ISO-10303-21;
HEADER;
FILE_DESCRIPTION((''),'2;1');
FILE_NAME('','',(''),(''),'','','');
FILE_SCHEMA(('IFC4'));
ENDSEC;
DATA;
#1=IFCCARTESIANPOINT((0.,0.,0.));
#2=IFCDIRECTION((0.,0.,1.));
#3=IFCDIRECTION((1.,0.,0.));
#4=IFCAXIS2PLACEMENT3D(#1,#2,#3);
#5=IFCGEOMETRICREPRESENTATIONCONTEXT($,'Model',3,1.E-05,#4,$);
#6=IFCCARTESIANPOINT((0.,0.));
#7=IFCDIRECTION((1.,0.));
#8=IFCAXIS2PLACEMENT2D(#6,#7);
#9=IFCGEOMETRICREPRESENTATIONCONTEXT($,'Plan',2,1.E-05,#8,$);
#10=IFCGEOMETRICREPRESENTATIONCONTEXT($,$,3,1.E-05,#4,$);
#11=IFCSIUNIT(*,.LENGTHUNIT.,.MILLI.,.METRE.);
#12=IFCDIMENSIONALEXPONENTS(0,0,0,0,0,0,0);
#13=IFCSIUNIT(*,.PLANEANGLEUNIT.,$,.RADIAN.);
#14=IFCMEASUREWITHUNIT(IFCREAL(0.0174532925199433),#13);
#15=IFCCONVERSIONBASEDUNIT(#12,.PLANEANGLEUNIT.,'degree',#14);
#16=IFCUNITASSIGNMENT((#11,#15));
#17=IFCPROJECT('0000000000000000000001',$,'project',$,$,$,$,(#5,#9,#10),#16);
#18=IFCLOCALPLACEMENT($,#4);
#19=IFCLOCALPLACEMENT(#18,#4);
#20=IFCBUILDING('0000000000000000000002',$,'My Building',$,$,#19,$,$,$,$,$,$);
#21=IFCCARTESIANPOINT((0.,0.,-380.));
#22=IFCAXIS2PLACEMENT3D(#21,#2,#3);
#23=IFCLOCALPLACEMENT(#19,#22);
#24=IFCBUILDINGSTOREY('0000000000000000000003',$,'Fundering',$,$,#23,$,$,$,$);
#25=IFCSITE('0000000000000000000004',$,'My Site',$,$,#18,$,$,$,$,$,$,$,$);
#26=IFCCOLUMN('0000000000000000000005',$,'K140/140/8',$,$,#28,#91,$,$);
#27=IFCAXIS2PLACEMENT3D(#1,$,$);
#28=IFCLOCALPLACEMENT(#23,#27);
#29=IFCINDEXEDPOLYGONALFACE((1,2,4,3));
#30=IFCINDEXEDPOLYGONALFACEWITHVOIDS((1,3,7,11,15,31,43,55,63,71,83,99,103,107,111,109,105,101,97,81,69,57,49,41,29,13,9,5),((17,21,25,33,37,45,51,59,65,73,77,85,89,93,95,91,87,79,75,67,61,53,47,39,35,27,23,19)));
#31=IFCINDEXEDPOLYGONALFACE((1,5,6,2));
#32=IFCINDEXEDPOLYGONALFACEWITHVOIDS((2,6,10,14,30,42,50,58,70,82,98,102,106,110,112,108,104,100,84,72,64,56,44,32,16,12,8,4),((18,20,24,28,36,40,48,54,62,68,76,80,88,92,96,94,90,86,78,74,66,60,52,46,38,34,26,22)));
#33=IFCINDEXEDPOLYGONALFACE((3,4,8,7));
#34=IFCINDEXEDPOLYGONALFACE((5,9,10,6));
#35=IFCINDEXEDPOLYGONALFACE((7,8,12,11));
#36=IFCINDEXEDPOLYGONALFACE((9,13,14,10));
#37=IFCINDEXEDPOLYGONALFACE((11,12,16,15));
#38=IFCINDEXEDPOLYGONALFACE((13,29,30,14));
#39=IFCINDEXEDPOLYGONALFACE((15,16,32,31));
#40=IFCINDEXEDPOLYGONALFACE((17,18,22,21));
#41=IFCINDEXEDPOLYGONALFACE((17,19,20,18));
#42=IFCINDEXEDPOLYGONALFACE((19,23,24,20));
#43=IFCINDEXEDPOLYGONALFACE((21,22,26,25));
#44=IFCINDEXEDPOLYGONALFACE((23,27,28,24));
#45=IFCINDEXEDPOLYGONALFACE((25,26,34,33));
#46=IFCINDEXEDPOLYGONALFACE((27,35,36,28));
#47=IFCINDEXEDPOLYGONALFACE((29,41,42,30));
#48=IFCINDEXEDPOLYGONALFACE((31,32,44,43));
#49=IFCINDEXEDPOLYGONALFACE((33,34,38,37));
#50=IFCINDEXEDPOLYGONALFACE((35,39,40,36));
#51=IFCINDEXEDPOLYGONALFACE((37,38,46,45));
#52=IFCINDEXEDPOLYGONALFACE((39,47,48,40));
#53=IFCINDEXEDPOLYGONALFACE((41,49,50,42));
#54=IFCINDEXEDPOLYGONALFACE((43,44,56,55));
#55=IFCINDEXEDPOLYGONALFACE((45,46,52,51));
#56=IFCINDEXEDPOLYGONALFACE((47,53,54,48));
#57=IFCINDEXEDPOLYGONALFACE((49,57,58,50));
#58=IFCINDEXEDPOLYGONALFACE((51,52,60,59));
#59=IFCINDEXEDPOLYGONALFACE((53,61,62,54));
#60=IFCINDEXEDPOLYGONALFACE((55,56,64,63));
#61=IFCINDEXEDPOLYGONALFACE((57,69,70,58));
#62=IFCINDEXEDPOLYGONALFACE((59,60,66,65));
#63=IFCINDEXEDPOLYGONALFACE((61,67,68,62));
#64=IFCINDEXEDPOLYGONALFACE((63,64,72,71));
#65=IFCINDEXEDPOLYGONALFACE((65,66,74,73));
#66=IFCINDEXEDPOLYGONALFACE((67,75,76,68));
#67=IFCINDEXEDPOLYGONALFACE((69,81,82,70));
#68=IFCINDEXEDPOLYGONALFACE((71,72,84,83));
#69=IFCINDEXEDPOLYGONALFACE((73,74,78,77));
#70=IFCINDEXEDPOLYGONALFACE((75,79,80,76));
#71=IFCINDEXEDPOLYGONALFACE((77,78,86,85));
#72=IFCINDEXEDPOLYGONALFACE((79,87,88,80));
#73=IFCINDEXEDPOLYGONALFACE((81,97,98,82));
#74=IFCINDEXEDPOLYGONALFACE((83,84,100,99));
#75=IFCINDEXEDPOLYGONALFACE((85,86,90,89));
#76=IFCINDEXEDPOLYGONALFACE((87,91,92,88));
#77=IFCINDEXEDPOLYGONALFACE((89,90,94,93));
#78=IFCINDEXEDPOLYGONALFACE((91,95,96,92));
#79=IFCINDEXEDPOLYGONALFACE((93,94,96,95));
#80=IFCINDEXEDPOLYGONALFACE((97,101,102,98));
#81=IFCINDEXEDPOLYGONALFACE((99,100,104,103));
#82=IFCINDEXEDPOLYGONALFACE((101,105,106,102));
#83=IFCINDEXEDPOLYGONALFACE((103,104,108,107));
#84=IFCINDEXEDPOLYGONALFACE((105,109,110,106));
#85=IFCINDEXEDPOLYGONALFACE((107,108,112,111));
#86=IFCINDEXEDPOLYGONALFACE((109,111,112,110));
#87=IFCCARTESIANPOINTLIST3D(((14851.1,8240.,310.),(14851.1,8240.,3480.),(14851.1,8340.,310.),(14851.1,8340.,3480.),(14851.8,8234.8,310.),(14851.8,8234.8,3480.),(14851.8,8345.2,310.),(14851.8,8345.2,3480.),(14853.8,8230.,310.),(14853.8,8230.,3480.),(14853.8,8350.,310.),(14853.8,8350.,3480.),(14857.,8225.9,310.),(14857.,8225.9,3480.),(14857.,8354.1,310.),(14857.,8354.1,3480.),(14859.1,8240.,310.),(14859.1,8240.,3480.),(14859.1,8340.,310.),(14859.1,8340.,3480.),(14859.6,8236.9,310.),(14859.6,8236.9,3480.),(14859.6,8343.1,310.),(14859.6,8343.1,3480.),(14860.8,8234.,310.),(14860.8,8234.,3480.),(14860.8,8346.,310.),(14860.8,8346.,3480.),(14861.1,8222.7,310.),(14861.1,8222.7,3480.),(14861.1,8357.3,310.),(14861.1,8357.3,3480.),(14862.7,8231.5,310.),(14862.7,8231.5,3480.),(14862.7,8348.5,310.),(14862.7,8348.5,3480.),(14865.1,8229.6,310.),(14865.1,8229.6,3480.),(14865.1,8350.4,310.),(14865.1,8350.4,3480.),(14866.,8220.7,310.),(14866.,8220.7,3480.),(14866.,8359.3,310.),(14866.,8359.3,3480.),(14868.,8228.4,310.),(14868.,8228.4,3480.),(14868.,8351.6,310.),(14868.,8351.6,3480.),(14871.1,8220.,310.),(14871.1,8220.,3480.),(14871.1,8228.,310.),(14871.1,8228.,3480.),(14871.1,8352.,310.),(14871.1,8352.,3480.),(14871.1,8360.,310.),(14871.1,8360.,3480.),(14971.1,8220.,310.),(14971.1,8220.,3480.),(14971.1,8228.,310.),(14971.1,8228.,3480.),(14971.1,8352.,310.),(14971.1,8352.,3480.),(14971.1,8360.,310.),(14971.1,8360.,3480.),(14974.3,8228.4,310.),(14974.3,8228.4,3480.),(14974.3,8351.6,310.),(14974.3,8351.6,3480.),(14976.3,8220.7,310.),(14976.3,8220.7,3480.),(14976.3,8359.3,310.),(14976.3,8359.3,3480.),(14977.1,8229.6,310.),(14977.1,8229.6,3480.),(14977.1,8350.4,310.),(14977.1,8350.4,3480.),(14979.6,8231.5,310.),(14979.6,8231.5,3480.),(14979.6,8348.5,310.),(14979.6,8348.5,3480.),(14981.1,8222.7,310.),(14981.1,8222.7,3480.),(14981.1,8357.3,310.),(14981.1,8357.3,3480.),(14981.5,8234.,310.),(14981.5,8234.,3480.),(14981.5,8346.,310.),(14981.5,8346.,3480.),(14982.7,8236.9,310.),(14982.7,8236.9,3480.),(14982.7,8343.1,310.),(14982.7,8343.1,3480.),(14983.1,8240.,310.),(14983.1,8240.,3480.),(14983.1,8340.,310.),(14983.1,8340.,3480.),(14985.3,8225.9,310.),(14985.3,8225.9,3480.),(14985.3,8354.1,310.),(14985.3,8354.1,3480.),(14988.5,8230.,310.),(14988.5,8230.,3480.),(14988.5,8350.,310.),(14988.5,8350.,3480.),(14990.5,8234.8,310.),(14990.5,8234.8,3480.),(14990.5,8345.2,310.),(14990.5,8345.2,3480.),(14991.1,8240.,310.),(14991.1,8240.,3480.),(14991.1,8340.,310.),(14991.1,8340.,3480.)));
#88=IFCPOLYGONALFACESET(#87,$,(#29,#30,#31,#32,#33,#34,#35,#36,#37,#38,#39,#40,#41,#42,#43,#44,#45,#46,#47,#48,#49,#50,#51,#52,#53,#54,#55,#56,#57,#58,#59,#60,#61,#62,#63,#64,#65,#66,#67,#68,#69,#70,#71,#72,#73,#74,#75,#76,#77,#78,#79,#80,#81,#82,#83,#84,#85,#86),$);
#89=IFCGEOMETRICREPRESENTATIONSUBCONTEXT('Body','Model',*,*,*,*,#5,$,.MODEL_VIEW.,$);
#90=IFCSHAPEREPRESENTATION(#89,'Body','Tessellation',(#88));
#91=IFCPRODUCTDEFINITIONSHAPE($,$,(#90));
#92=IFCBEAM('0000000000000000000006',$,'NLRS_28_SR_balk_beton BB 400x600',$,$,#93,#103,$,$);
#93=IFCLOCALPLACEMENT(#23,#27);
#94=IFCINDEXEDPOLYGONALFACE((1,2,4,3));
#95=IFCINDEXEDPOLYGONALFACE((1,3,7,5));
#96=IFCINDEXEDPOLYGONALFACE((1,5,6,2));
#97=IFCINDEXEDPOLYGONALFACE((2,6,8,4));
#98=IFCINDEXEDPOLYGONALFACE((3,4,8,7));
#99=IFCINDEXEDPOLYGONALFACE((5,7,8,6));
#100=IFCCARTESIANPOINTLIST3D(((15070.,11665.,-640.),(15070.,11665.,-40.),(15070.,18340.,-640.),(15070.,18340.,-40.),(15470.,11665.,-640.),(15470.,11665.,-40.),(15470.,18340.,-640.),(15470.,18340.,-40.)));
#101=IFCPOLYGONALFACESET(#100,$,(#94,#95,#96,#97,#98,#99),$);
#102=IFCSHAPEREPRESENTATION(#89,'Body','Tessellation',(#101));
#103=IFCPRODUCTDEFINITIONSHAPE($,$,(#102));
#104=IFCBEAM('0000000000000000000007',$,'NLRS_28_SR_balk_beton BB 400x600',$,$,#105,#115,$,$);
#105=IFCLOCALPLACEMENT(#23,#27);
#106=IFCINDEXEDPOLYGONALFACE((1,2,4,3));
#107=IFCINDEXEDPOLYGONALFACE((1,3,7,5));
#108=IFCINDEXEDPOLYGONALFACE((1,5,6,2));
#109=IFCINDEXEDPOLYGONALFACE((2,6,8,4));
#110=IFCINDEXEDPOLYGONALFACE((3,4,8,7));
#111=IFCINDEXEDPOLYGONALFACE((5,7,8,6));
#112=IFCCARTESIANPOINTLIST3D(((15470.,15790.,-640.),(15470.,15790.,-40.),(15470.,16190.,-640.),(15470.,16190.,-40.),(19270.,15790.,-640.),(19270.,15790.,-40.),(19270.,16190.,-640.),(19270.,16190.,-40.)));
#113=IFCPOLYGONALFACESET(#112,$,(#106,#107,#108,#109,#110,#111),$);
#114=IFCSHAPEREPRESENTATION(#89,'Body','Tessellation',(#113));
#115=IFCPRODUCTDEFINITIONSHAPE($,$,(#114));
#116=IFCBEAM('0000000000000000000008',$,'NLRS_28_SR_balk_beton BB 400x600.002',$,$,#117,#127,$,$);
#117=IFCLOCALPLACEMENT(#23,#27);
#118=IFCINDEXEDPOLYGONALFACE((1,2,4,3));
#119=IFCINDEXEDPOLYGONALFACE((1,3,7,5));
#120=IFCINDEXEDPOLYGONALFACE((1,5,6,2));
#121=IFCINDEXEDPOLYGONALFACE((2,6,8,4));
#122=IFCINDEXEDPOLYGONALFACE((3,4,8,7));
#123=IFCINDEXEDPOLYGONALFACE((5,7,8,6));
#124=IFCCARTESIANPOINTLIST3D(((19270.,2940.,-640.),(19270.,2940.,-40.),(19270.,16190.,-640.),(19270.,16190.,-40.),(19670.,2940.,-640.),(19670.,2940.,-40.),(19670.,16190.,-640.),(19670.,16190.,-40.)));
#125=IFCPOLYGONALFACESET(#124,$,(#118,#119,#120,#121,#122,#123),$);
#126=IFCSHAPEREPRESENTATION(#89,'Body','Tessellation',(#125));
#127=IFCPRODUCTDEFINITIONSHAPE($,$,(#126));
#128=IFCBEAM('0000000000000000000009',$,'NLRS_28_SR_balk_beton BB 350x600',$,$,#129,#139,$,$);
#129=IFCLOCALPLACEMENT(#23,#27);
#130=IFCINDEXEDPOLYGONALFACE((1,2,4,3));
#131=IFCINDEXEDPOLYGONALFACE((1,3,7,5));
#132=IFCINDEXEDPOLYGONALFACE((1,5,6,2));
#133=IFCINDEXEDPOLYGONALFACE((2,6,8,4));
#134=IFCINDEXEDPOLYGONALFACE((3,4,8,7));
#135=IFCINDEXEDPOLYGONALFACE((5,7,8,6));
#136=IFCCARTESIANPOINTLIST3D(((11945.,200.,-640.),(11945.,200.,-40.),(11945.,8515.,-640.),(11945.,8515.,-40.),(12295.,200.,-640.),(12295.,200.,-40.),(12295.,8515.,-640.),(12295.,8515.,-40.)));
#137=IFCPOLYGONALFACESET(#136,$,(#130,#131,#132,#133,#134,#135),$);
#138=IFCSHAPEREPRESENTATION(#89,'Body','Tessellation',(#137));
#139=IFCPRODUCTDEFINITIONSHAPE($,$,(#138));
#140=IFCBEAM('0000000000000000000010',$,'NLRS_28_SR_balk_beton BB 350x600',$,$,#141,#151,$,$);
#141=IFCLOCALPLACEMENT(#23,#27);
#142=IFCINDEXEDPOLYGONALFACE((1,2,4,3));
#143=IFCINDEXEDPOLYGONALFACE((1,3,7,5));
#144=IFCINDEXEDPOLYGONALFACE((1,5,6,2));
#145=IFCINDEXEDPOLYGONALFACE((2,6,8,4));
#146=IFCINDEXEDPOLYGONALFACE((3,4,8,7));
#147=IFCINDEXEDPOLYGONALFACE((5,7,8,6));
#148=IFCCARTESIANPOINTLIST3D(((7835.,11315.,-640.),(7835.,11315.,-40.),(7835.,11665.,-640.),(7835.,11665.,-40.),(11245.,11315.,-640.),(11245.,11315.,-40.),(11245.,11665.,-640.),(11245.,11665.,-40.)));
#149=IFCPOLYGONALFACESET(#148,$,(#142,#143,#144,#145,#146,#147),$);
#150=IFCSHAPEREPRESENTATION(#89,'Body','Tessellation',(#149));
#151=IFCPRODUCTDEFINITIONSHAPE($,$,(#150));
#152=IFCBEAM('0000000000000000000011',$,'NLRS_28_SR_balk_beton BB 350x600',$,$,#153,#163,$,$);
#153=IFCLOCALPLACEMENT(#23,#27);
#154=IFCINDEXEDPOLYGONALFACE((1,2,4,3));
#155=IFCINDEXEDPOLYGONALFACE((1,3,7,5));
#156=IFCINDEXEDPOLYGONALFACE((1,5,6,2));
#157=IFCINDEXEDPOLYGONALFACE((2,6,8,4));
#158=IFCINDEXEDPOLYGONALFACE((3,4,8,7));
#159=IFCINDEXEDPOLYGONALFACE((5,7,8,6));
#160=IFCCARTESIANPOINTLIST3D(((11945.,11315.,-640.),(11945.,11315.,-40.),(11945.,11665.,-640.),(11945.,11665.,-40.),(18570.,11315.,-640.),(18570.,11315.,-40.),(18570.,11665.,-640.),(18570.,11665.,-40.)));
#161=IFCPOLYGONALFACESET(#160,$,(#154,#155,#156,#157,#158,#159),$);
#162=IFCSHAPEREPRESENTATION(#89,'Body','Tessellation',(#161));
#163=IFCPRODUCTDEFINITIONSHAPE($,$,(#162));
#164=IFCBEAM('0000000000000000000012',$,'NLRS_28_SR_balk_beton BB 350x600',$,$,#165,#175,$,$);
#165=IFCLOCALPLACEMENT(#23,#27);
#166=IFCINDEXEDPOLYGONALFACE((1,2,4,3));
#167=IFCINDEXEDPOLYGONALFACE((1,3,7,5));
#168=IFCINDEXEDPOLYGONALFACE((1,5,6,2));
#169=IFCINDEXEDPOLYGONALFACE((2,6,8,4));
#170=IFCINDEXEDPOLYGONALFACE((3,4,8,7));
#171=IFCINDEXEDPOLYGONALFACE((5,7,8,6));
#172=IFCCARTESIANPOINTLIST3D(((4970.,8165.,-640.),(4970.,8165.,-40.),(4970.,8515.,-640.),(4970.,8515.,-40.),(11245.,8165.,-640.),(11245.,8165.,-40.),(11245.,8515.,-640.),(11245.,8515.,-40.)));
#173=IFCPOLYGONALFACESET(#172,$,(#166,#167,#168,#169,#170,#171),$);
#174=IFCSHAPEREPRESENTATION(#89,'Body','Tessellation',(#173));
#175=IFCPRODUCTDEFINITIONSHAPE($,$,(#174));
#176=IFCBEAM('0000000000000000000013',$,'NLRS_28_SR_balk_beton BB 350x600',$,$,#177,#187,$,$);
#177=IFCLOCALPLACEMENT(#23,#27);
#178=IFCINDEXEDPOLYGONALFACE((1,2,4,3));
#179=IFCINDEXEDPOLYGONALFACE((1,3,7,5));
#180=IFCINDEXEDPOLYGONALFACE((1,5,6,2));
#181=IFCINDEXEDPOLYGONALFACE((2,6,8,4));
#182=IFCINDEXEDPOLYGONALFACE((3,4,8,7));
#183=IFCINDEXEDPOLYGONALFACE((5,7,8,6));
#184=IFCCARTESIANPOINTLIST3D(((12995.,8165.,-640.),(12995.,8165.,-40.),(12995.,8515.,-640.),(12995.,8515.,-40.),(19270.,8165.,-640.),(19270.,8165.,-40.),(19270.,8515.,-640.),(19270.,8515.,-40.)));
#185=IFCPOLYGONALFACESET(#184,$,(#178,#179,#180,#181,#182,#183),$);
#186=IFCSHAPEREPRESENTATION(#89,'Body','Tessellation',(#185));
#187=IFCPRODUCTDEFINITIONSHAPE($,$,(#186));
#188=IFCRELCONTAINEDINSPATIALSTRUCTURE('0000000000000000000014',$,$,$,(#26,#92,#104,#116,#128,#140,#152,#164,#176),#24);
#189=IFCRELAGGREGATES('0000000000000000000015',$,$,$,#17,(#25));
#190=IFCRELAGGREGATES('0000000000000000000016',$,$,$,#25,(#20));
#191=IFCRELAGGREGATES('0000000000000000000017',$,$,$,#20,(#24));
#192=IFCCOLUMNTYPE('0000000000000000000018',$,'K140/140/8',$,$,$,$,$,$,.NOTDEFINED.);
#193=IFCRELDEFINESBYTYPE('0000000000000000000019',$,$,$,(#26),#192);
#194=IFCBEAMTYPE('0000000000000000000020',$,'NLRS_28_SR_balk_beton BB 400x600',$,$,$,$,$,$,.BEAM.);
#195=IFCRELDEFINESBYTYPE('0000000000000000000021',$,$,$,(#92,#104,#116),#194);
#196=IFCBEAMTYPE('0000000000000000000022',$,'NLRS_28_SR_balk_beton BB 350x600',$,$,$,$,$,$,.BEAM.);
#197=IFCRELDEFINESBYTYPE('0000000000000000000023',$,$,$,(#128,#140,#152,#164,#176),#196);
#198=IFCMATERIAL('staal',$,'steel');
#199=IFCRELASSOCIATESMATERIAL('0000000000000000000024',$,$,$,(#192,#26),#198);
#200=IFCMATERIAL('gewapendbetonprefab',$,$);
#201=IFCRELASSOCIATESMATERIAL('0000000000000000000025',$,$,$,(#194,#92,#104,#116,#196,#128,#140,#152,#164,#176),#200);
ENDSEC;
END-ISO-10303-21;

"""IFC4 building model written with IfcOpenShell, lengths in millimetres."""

from ifc_helpers import new_model, entity, si_unit, converted_unit, frame, origin_with_axes, origin_2d_with_axis, place, context, subcontext, project, spatial, rectangle, hollow_rectangle, extrude, material, material_profile, profile_set, profile_usage, type_object, element, save


model = new_model("IFC4")

# Units and contexts
model_context = context("Model", 3, precision=1e-05, world=origin_with_axes())
plan_context = context("Plan", 2, precision=1e-05, world=origin_2d_with_axis())
context_of_model = context(None, 3, precision=1e-05, world=origin_with_axes())
body_context = subcontext(model_context, "Body", "Model", "MODEL_VIEW")
ifc_project = project(units=[si_unit("LENGTHUNIT", "METRE", prefix="MILLI"), converted_unit("PLANEANGLEUNIT", "degree", entity("IfcReal", 0.0174532925199433), si_unit("PLANEANGLEUNIT", "RADIAN"), dimensions=[0, 0, 0, 0, 0, 0, 0])], contexts=[model_context, plan_context, context_of_model])

# Site, building, storey
site_placement = place(None, origin_with_axes())
site = spatial("IfcSite", under=ifc_project, at=site_placement, Name="My Site")
building_placement = place(site_placement, origin_with_axes())
building = spatial("IfcBuilding", under=site, at=building_placement, Name="My Building")
storey_placement = place(building_placement, frame((0.0, 0.0, -380.0), z_axis=(0.0, 0.0, 1.0), x_axis=(1.0, 0.0, 0.0)))
storey = spatial("IfcBuildingStorey", under=building, at=storey_placement, Name="Fundering")

# Column
ifc_material_1 = material(Name="staal", Category="steel")
ifc_material_profile_1 = material_profile(ifc_material_1, hollow_rectangle(XDim=140.0, YDim=140.0, WallThickness=8.0, InnerFilletRadius=12.0, OuterFilletRadius=20.0))
ifc_profile_set_1 = profile_set([ifc_material_profile_1], Name="K140/140/8")
ifc_profile_usage_1 = profile_usage(ifc_profile_set_1, cardinal=7)
column_type = type_object("IfcColumnType", Name="K140/140/8", PredefinedType="NOTDEFINED", material=ifc_profile_set_1)
column_placement = place(storey_placement, frame((14991.1, 8360.0, 310.0), z_axis=(0.0, 0.0, 1.0), x_axis=(1.0, 0.0, 0.0)))
element("IfcColumn", 1, at=column_placement, inside=storey, type_object=column_type, material=ifc_profile_usage_1, Name="K140/140/8", context=body_context, shape_type="SweptSolid", body=[
    extrude(hollow_rectangle(XDim=140.0, YDim=140.0, WallThickness=8.0, InnerFilletRadius=12.0, OuterFilletRadius=20.0), frame((-70.0, -70.0, 0.0), z_axis=(0.0, 0.0, 1.0), x_axis=(1.0, 0.0, 0.0)), (0.0, 0.0, 1.0), 3170.0),
])

# Beams
ifc_material_2 = material(Name="gewapendbetonprefab")
ifc_material_profile_2 = material_profile(ifc_material_2, rectangle(XDim=400.0, YDim=600.0))
ifc_profile_set_2 = profile_set([ifc_material_profile_2], Name="NLRS_28_SR_balk_beton BB 400x600")
ifc_profile_usage_2 = profile_usage(ifc_profile_set_2, cardinal=8)
beam_type_1 = type_object("IfcBeamType", Name="NLRS_28_SR_balk_beton BB 400x600", PredefinedType="BEAM", material=ifc_profile_set_2)
beam_1_placement = place(storey_placement, frame((15270.0, 11665.0, -40.0), z_axis=(0.0, 1.0, 0.0), x_axis=(-1.0, 0.0, 0.0)))
element("IfcBeam", 2, at=beam_1_placement, inside=storey, type_object=beam_type_1, material=ifc_profile_usage_2, Name="NLRS_28_SR_balk_beton BB 400x600", context=body_context, shape_type="SweptSolid", body=[
    extrude(rectangle(XDim=400.0, YDim=600.0), frame((0.0, -300.0, 0.0), z_axis=(0.0, 0.0, 1.0), x_axis=(1.0, 0.0, 0.0)), (0.0, 0.0, 1.0), 6675.0),
])
ifc_profile_usage_3 = profile_usage(ifc_profile_set_2, cardinal=8)
beam_2_placement = place(storey_placement, frame((19270.0, 15990.0, -40.0), z_axis=(-1.0, 0.0, 0.0), x_axis=(0.0, -1.0, 0.0)))
element("IfcBeam", 3, at=beam_2_placement, inside=storey, type_object=beam_type_1, material=ifc_profile_usage_3, Name="NLRS_28_SR_balk_beton BB 400x600", context=body_context, shape_type="SweptSolid", body=[
    extrude(rectangle(XDim=400.0, YDim=600.0), frame((0.0, -300.0, 0.0), z_axis=(0.0, 0.0, 1.0), x_axis=(1.0, 0.0, 0.0)), (0.0, 0.0, 1.0), 3800.0),
])
ifc_profile_usage_4 = profile_usage(ifc_profile_set_2, cardinal=8)
beam_3_placement = place(storey_placement, frame((19470.0, 2940.0, -40.0), z_axis=(0.0, 1.0, 0.0), x_axis=(-1.0, 0.0, 0.0)))
element("IfcBeam", 4, at=beam_3_placement, inside=storey, type_object=beam_type_1, material=ifc_profile_usage_4, Name="NLRS_28_SR_balk_beton BB 400x600.002", context=body_context, shape_type="SweptSolid", body=[
    extrude(rectangle(XDim=400.0, YDim=600.0), frame((0.0, -300.0, 0.0), z_axis=(0.0, 0.0, 1.0), x_axis=(1.0, 0.0, 0.0)), (0.0, 0.0, 1.0), 13250.0),
])
ifc_material_profile_3 = material_profile(ifc_material_2, rectangle(XDim=350.0, YDim=600.0))
ifc_profile_set_3 = profile_set([ifc_material_profile_3], Name="NLRS_28_SR_balk_beton BB 350x600")
ifc_profile_usage_5 = profile_usage(ifc_profile_set_3)
beam_type_2 = type_object("IfcBeamType", Name="NLRS_28_SR_balk_beton BB 350x600", PredefinedType="BEAM", material=ifc_profile_set_3)
beam_4_placement = place(storey_placement, frame((12120.0, 200.0, -340.0), z_axis=(0.0, 1.0, 0.0), x_axis=(-1.0, 0.0, 0.0)))
element("IfcBeam", 5, at=beam_4_placement, inside=storey, type_object=beam_type_2, material=ifc_profile_usage_5, Name="NLRS_28_SR_balk_beton BB 350x600", context=body_context, shape_type="SweptSolid", body=[
    extrude(rectangle(XDim=350.0, YDim=600.0), origin_with_axes(), (0.0, 0.0, 1.0), 8315.0),
])
ifc_profile_usage_6 = profile_usage(ifc_profile_set_3, cardinal=8)
beam_5_placement = place(storey_placement, frame((11245.0, 11490.0, -40.0), z_axis=(-1.0, 0.0, 0.0), x_axis=(0.0, -1.0, 0.0)))
element("IfcBeam", 6, at=beam_5_placement, inside=storey, type_object=beam_type_2, material=ifc_profile_usage_6, Name="NLRS_28_SR_balk_beton BB 350x600", context=body_context, shape_type="SweptSolid", body=[
    extrude(rectangle(XDim=350.0, YDim=600.0), frame((0.0, -300.0, 0.0), z_axis=(0.0, 0.0, 1.0), x_axis=(1.0, 0.0, 0.0)), (0.0, 0.0, 1.0), 3410.0),
])
ifc_profile_usage_7 = profile_usage(ifc_profile_set_3, cardinal=8)
beam_6_placement = place(storey_placement, frame((18570.0, 11490.0, -40.0), z_axis=(-1.0, 0.0, 0.0), x_axis=(0.0, -1.0, 0.0)))
element("IfcBeam", 7, at=beam_6_placement, inside=storey, type_object=beam_type_2, material=ifc_profile_usage_7, Name="NLRS_28_SR_balk_beton BB 350x600", context=body_context, shape_type="SweptSolid", body=[
    extrude(rectangle(XDim=350.0, YDim=600.0), frame((0.0, -300.0, 0.0), z_axis=(0.0, 0.0, 1.0), x_axis=(1.0, 0.0, 0.0)), (0.0, 0.0, 1.0), 6625.0),
])
ifc_profile_usage_8 = profile_usage(ifc_profile_set_3, cardinal=8)
beam_7_placement = place(storey_placement, frame((11245.0, 8340.0, -40.0), z_axis=(-1.0, 0.0, 0.0), x_axis=(0.0, -1.0, 0.0)))
element("IfcBeam", 8, at=beam_7_placement, inside=storey, type_object=beam_type_2, material=ifc_profile_usage_8, Name="NLRS_28_SR_balk_beton BB 350x600", context=body_context, shape_type="SweptSolid", body=[
    extrude(rectangle(XDim=350.0, YDim=600.0), frame((0.0, -300.0, 0.0), z_axis=(0.0, 0.0, 1.0), x_axis=(1.0, 0.0, 0.0)), (0.0, 0.0, 1.0), 6275.0),
])
ifc_profile_usage_9 = profile_usage(ifc_profile_set_3, cardinal=8)
beam_8_placement = place(storey_placement, frame((19270.0, 8340.0, -40.0), z_axis=(-1.0, 0.0, 0.0), x_axis=(0.0, -1.0, 0.0)))
element("IfcBeam", 9, at=beam_8_placement, inside=storey, type_object=beam_type_2, material=ifc_profile_usage_9, Name="NLRS_28_SR_balk_beton BB 350x600", context=body_context, shape_type="SweptSolid", body=[
    extrude(rectangle(XDim=350.0, YDim=600.0), frame((0.0, -300.0, 0.0), z_axis=(0.0, 0.0, 1.0), x_axis=(1.0, 0.0, 0.0)), (0.0, 0.0, 1.0), 6275.0),
])

save(model, "model.ifc")
